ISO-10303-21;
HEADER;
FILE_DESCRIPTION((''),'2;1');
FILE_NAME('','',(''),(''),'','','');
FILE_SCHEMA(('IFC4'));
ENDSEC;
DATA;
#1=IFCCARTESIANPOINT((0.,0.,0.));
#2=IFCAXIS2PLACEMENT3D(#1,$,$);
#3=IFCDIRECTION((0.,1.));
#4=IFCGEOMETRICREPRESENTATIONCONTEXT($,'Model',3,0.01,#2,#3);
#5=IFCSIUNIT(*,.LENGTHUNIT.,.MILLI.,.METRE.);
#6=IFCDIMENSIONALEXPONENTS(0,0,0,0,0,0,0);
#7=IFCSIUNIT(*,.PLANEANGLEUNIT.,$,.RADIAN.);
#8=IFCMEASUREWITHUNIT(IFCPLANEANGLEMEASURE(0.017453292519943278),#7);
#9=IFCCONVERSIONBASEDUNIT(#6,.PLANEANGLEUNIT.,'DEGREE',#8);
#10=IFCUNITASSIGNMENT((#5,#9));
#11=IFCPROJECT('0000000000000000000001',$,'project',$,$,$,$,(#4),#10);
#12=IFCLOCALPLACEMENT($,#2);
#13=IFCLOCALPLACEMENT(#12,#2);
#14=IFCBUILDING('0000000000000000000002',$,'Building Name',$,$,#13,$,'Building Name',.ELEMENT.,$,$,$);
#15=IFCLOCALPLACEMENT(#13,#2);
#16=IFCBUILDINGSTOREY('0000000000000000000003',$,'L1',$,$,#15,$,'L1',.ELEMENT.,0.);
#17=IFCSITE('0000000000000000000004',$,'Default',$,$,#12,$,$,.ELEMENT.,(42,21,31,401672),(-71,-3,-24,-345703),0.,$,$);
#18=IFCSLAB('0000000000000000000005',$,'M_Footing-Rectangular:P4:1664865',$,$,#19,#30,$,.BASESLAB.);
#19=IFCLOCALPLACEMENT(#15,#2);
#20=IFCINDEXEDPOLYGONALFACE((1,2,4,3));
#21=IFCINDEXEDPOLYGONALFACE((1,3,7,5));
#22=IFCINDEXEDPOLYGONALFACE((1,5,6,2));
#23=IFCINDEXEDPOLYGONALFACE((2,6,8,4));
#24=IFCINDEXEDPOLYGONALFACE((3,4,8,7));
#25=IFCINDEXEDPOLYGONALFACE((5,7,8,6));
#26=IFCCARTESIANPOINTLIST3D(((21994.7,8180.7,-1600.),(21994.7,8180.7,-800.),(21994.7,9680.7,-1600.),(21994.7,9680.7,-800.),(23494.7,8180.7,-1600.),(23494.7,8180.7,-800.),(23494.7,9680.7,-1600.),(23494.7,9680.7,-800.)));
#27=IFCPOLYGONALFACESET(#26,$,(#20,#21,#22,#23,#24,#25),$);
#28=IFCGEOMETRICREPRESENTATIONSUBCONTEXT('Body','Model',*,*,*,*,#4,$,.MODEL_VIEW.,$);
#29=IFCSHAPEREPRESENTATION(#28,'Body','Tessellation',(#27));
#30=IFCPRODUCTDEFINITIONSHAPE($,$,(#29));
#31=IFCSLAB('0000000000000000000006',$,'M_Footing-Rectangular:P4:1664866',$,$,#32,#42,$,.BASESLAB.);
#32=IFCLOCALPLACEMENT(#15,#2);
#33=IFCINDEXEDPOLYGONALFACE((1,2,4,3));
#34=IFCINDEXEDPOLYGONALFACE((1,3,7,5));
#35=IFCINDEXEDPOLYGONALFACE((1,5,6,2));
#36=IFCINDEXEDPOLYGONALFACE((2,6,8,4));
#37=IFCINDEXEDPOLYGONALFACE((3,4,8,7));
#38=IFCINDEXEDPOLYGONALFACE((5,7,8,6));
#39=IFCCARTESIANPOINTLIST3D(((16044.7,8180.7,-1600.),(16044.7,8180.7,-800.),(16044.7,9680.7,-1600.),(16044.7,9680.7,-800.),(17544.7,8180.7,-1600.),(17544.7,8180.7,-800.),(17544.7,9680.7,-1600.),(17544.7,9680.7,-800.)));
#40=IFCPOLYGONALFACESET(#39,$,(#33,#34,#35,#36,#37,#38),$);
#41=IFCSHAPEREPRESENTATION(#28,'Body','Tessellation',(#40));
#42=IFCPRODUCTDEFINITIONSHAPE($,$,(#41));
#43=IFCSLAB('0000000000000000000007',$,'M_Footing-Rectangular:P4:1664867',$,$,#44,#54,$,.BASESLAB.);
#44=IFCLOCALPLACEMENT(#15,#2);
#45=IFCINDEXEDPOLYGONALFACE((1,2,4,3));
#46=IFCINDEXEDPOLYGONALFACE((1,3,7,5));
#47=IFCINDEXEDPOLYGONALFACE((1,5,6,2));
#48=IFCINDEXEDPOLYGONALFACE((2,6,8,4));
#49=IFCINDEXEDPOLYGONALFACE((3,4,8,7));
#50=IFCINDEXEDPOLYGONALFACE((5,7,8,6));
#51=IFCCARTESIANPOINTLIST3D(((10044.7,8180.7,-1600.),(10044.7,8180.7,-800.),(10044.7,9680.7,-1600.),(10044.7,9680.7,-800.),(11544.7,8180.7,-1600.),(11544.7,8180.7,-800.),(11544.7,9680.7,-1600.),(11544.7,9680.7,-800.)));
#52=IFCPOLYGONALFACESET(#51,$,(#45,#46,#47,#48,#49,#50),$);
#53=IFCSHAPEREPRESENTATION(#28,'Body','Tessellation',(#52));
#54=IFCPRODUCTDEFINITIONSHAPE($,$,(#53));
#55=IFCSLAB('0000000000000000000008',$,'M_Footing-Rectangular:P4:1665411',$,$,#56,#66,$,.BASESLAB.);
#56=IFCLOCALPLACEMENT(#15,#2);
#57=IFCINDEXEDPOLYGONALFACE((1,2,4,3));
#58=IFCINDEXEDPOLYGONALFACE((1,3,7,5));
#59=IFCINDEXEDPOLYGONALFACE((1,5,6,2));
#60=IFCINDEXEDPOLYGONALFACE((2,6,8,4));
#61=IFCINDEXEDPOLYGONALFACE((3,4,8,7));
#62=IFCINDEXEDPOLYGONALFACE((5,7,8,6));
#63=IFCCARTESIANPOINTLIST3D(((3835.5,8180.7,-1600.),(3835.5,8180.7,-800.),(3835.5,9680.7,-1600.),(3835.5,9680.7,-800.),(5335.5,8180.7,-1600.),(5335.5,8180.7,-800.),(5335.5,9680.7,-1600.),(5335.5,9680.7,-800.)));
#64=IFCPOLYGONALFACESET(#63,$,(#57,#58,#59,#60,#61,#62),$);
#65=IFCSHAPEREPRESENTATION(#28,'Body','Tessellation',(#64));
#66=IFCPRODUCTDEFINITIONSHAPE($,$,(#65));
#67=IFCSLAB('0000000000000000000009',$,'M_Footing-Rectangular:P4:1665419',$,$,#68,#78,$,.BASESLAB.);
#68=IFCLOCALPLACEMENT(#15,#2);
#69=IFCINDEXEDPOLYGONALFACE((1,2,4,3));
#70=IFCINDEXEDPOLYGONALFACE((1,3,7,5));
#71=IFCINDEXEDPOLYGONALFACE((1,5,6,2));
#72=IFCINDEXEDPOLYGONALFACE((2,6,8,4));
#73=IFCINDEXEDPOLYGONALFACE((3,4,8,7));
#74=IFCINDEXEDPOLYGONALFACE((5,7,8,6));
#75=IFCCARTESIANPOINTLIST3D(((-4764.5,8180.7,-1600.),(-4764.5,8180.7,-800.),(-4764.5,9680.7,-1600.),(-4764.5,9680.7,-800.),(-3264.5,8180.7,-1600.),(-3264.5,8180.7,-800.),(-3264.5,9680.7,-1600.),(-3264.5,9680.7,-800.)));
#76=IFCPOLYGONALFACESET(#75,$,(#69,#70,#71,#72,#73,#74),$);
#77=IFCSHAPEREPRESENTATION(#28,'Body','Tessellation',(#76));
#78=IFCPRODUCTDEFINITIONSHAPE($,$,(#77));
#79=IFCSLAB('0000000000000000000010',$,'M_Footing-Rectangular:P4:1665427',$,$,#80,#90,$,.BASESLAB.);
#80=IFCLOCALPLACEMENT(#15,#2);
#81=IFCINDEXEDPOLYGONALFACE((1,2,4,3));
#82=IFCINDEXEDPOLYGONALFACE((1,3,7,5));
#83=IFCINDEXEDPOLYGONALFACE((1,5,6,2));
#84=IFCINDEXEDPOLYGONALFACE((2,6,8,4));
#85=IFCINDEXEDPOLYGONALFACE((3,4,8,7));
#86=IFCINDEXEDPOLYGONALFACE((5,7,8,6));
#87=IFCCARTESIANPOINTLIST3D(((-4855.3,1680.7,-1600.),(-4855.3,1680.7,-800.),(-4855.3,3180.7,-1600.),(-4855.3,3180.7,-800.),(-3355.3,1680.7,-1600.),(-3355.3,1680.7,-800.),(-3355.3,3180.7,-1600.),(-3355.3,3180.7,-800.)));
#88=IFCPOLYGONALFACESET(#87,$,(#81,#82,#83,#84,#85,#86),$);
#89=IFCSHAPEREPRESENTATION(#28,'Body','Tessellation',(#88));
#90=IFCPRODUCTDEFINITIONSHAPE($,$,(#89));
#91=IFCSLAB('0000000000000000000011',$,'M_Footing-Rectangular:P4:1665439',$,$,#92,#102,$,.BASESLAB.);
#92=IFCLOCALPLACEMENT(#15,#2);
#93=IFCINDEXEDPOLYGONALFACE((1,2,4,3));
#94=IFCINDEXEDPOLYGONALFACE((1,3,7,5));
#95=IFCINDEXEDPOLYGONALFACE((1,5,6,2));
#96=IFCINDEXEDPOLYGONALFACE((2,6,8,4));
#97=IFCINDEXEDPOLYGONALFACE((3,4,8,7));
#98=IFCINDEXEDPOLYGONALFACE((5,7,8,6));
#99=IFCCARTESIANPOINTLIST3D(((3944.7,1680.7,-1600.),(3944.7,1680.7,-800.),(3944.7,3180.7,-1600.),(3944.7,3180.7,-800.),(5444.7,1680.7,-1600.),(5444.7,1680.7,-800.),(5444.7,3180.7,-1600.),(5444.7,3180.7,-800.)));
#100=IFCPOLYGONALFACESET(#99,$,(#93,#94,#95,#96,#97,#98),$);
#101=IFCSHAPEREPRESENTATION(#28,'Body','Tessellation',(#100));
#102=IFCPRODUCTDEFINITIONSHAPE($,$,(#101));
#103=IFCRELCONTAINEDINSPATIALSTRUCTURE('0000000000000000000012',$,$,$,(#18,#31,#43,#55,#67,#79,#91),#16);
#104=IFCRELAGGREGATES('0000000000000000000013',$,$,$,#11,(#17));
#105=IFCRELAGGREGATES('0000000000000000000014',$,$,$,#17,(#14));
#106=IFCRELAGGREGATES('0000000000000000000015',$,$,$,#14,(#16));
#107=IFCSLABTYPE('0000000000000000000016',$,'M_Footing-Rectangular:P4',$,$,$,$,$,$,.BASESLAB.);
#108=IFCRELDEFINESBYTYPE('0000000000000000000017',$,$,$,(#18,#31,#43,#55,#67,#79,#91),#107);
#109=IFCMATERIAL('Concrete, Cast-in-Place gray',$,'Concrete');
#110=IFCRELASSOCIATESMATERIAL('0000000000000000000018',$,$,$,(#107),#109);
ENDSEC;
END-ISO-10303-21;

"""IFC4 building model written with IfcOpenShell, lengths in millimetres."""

from ifc_helpers import new_model, entity, si_unit, converted_unit, direction, frame, origin, place, context, subcontext, project, spatial, indexed_curve, outline, extrude, material, type_object, element, save


model = new_model("IFC4")

# Units and contexts
model_context = context("Model", 3, precision=0.01, world=origin(), true_north=direction((0.0, 1.0)))
body_context = subcontext(model_context, "Body", "Model", "MODEL_VIEW")
ifc_project = project(units=[si_unit("LENGTHUNIT", "METRE", prefix="MILLI"), converted_unit("PLANEANGLEUNIT", "DEGREE", entity("IfcPlaneAngleMeasure", 0.017453292519943278), si_unit("PLANEANGLEUNIT", "RADIAN"), dimensions=[0, 0, 0, 0, 0, 0, 0])], contexts=[model_context])

# Site, building, storey
site_placement = place(None, origin())
site = spatial("IfcSite", under=ifc_project, at=site_placement, Name="Default", CompositionType="ELEMENT", RefLatitude=(42, 21, 31, 401672), RefLongitude=(-71, -3, -24, -345703), RefElevation=0.0)
building_placement = place(site_placement, origin())
building = spatial("IfcBuilding", under=site, at=building_placement, Name="Building Name", LongName="Building Name", CompositionType="ELEMENT")
storey_placement = place(building_placement, origin())
storey = spatial("IfcBuildingStorey", under=building, at=storey_placement, Name="L1", LongName="L1", CompositionType="ELEMENT", Elevation=0.0)

# Slabs
ifc_material = material(Name="Concrete, Cast-in-Place gray", Category="Concrete")
slab_type = type_object("IfcSlabType", Name="M_Footing-Rectangular:P4", PredefinedType="BASESLAB", material=ifc_material)
slab_1_placement = place(storey_placement, origin())
element("IfcSlab", 1, at=slab_1_placement, inside=storey, type_object=slab_type, Name="M_Footing-Rectangular:P4:1664865", PredefinedType="BASESLAB", context=body_context, shape_type="SweptSolid", body=[
    extrude(outline(indexed_curve([(-750.0, -750.0), (750.0, -750.0), (750.0, 750.0), (-750.0, 750.0), (-750.0, -750.0)], self_intersect=False)), frame((22744.7, 8930.7, -1600.0), z_axis=(0.0, 0.0, 1.0), x_axis=(-1.0, 0.0, 0.0)), (0.0, 0.0, 1.0), 800.0),
])
slab_2_placement = place(storey_placement, origin())
element("IfcSlab", 2, at=slab_2_placement, inside=storey, type_object=slab_type, Name="M_Footing-Rectangular:P4:1664866", PredefinedType="BASESLAB", context=body_context, shape_type="SweptSolid", body=[
    extrude(outline(indexed_curve([(-750.0, -750.0), (750.0, -750.0), (750.0, 750.0), (-750.0, 750.0), (-750.0, -750.0)], self_intersect=False)), frame((16794.7, 8930.7, -1600.0), z_axis=(0.0, 0.0, 1.0), x_axis=(-1.0, 0.0, 0.0)), (0.0, 0.0, 1.0), 800.0),
])
slab_3_placement = place(storey_placement, origin())
element("IfcSlab", 3, at=slab_3_placement, inside=storey, type_object=slab_type, Name="M_Footing-Rectangular:P4:1664867", PredefinedType="BASESLAB", context=body_context, shape_type="SweptSolid", body=[
    extrude(outline(indexed_curve([(-750.0, -750.0), (750.0, -750.0), (750.0, 750.0), (-750.0, 750.0), (-750.0, -750.0)], self_intersect=False)), frame((10794.7, 8930.7, -1600.0), z_axis=(0.0, 0.0, 1.0), x_axis=(-1.0, 0.0, 0.0)), (0.0, 0.0, 1.0), 800.0),
])
slab_4_placement = place(storey_placement, origin())
element("IfcSlab", 4, at=slab_4_placement, inside=storey, type_object=slab_type, Name="M_Footing-Rectangular:P4:1665411", PredefinedType="BASESLAB", context=body_context, shape_type="SweptSolid", body=[
    extrude(outline(indexed_curve([(-750.0, -750.0), (750.0, -750.0), (750.0, 750.0), (-750.0, 750.0), (-750.0, -750.0)], self_intersect=False)), frame((4585.5, 8930.7, -1600.0), z_axis=(0.0, 0.0, 1.0), x_axis=(-1.0, 0.0, 0.0)), (0.0, 0.0, 1.0), 800.0),
])
slab_5_placement = place(storey_placement, origin())
element("IfcSlab", 5, at=slab_5_placement, inside=storey, type_object=slab_type, Name="M_Footing-Rectangular:P4:1665419", PredefinedType="BASESLAB", context=body_context, shape_type="SweptSolid", body=[
    extrude(outline(indexed_curve([(-750.0, -750.0), (750.0, -750.0), (750.0, 750.0), (-750.0, 750.0), (-750.0, -750.0)], self_intersect=False)), frame((-4014.5, 8930.7, -1600.0), z_axis=(0.0, 0.0, 1.0), x_axis=(-1.0, 0.0, 0.0)), (0.0, 0.0, 1.0), 800.0),
])
slab_6_placement = place(storey_placement, origin())
element("IfcSlab", 6, at=slab_6_placement, inside=storey, type_object=slab_type, Name="M_Footing-Rectangular:P4:1665427", PredefinedType="BASESLAB", context=body_context, shape_type="SweptSolid", body=[
    extrude(outline(indexed_curve([(-750.0, -750.0), (750.0, -750.0), (750.0, 750.0), (-750.0, 750.0), (-750.0, -750.0)], self_intersect=False)), frame((-4105.3, 2430.7, -1600.0), z_axis=(0.0, 0.0, 1.0), x_axis=(-1.0, 0.0, 0.0)), (0.0, 0.0, 1.0), 800.0),
])
slab_7_placement = place(storey_placement, origin())
element("IfcSlab", 7, at=slab_7_placement, inside=storey, type_object=slab_type, Name="M_Footing-Rectangular:P4:1665439", PredefinedType="BASESLAB", context=body_context, shape_type="SweptSolid", body=[
    extrude(outline(indexed_curve([(-750.0, -750.0), (750.0, -750.0), (750.0, 750.0), (-750.0, 750.0), (-750.0, -750.0)], self_intersect=False)), frame((4694.7, 2430.7, -1600.0), z_axis=(0.0, 0.0, 1.0), x_axis=(-1.0, 0.0, 0.0)), (0.0, 0.0, 1.0), 800.0),
])

save(model, "model.ifc")
